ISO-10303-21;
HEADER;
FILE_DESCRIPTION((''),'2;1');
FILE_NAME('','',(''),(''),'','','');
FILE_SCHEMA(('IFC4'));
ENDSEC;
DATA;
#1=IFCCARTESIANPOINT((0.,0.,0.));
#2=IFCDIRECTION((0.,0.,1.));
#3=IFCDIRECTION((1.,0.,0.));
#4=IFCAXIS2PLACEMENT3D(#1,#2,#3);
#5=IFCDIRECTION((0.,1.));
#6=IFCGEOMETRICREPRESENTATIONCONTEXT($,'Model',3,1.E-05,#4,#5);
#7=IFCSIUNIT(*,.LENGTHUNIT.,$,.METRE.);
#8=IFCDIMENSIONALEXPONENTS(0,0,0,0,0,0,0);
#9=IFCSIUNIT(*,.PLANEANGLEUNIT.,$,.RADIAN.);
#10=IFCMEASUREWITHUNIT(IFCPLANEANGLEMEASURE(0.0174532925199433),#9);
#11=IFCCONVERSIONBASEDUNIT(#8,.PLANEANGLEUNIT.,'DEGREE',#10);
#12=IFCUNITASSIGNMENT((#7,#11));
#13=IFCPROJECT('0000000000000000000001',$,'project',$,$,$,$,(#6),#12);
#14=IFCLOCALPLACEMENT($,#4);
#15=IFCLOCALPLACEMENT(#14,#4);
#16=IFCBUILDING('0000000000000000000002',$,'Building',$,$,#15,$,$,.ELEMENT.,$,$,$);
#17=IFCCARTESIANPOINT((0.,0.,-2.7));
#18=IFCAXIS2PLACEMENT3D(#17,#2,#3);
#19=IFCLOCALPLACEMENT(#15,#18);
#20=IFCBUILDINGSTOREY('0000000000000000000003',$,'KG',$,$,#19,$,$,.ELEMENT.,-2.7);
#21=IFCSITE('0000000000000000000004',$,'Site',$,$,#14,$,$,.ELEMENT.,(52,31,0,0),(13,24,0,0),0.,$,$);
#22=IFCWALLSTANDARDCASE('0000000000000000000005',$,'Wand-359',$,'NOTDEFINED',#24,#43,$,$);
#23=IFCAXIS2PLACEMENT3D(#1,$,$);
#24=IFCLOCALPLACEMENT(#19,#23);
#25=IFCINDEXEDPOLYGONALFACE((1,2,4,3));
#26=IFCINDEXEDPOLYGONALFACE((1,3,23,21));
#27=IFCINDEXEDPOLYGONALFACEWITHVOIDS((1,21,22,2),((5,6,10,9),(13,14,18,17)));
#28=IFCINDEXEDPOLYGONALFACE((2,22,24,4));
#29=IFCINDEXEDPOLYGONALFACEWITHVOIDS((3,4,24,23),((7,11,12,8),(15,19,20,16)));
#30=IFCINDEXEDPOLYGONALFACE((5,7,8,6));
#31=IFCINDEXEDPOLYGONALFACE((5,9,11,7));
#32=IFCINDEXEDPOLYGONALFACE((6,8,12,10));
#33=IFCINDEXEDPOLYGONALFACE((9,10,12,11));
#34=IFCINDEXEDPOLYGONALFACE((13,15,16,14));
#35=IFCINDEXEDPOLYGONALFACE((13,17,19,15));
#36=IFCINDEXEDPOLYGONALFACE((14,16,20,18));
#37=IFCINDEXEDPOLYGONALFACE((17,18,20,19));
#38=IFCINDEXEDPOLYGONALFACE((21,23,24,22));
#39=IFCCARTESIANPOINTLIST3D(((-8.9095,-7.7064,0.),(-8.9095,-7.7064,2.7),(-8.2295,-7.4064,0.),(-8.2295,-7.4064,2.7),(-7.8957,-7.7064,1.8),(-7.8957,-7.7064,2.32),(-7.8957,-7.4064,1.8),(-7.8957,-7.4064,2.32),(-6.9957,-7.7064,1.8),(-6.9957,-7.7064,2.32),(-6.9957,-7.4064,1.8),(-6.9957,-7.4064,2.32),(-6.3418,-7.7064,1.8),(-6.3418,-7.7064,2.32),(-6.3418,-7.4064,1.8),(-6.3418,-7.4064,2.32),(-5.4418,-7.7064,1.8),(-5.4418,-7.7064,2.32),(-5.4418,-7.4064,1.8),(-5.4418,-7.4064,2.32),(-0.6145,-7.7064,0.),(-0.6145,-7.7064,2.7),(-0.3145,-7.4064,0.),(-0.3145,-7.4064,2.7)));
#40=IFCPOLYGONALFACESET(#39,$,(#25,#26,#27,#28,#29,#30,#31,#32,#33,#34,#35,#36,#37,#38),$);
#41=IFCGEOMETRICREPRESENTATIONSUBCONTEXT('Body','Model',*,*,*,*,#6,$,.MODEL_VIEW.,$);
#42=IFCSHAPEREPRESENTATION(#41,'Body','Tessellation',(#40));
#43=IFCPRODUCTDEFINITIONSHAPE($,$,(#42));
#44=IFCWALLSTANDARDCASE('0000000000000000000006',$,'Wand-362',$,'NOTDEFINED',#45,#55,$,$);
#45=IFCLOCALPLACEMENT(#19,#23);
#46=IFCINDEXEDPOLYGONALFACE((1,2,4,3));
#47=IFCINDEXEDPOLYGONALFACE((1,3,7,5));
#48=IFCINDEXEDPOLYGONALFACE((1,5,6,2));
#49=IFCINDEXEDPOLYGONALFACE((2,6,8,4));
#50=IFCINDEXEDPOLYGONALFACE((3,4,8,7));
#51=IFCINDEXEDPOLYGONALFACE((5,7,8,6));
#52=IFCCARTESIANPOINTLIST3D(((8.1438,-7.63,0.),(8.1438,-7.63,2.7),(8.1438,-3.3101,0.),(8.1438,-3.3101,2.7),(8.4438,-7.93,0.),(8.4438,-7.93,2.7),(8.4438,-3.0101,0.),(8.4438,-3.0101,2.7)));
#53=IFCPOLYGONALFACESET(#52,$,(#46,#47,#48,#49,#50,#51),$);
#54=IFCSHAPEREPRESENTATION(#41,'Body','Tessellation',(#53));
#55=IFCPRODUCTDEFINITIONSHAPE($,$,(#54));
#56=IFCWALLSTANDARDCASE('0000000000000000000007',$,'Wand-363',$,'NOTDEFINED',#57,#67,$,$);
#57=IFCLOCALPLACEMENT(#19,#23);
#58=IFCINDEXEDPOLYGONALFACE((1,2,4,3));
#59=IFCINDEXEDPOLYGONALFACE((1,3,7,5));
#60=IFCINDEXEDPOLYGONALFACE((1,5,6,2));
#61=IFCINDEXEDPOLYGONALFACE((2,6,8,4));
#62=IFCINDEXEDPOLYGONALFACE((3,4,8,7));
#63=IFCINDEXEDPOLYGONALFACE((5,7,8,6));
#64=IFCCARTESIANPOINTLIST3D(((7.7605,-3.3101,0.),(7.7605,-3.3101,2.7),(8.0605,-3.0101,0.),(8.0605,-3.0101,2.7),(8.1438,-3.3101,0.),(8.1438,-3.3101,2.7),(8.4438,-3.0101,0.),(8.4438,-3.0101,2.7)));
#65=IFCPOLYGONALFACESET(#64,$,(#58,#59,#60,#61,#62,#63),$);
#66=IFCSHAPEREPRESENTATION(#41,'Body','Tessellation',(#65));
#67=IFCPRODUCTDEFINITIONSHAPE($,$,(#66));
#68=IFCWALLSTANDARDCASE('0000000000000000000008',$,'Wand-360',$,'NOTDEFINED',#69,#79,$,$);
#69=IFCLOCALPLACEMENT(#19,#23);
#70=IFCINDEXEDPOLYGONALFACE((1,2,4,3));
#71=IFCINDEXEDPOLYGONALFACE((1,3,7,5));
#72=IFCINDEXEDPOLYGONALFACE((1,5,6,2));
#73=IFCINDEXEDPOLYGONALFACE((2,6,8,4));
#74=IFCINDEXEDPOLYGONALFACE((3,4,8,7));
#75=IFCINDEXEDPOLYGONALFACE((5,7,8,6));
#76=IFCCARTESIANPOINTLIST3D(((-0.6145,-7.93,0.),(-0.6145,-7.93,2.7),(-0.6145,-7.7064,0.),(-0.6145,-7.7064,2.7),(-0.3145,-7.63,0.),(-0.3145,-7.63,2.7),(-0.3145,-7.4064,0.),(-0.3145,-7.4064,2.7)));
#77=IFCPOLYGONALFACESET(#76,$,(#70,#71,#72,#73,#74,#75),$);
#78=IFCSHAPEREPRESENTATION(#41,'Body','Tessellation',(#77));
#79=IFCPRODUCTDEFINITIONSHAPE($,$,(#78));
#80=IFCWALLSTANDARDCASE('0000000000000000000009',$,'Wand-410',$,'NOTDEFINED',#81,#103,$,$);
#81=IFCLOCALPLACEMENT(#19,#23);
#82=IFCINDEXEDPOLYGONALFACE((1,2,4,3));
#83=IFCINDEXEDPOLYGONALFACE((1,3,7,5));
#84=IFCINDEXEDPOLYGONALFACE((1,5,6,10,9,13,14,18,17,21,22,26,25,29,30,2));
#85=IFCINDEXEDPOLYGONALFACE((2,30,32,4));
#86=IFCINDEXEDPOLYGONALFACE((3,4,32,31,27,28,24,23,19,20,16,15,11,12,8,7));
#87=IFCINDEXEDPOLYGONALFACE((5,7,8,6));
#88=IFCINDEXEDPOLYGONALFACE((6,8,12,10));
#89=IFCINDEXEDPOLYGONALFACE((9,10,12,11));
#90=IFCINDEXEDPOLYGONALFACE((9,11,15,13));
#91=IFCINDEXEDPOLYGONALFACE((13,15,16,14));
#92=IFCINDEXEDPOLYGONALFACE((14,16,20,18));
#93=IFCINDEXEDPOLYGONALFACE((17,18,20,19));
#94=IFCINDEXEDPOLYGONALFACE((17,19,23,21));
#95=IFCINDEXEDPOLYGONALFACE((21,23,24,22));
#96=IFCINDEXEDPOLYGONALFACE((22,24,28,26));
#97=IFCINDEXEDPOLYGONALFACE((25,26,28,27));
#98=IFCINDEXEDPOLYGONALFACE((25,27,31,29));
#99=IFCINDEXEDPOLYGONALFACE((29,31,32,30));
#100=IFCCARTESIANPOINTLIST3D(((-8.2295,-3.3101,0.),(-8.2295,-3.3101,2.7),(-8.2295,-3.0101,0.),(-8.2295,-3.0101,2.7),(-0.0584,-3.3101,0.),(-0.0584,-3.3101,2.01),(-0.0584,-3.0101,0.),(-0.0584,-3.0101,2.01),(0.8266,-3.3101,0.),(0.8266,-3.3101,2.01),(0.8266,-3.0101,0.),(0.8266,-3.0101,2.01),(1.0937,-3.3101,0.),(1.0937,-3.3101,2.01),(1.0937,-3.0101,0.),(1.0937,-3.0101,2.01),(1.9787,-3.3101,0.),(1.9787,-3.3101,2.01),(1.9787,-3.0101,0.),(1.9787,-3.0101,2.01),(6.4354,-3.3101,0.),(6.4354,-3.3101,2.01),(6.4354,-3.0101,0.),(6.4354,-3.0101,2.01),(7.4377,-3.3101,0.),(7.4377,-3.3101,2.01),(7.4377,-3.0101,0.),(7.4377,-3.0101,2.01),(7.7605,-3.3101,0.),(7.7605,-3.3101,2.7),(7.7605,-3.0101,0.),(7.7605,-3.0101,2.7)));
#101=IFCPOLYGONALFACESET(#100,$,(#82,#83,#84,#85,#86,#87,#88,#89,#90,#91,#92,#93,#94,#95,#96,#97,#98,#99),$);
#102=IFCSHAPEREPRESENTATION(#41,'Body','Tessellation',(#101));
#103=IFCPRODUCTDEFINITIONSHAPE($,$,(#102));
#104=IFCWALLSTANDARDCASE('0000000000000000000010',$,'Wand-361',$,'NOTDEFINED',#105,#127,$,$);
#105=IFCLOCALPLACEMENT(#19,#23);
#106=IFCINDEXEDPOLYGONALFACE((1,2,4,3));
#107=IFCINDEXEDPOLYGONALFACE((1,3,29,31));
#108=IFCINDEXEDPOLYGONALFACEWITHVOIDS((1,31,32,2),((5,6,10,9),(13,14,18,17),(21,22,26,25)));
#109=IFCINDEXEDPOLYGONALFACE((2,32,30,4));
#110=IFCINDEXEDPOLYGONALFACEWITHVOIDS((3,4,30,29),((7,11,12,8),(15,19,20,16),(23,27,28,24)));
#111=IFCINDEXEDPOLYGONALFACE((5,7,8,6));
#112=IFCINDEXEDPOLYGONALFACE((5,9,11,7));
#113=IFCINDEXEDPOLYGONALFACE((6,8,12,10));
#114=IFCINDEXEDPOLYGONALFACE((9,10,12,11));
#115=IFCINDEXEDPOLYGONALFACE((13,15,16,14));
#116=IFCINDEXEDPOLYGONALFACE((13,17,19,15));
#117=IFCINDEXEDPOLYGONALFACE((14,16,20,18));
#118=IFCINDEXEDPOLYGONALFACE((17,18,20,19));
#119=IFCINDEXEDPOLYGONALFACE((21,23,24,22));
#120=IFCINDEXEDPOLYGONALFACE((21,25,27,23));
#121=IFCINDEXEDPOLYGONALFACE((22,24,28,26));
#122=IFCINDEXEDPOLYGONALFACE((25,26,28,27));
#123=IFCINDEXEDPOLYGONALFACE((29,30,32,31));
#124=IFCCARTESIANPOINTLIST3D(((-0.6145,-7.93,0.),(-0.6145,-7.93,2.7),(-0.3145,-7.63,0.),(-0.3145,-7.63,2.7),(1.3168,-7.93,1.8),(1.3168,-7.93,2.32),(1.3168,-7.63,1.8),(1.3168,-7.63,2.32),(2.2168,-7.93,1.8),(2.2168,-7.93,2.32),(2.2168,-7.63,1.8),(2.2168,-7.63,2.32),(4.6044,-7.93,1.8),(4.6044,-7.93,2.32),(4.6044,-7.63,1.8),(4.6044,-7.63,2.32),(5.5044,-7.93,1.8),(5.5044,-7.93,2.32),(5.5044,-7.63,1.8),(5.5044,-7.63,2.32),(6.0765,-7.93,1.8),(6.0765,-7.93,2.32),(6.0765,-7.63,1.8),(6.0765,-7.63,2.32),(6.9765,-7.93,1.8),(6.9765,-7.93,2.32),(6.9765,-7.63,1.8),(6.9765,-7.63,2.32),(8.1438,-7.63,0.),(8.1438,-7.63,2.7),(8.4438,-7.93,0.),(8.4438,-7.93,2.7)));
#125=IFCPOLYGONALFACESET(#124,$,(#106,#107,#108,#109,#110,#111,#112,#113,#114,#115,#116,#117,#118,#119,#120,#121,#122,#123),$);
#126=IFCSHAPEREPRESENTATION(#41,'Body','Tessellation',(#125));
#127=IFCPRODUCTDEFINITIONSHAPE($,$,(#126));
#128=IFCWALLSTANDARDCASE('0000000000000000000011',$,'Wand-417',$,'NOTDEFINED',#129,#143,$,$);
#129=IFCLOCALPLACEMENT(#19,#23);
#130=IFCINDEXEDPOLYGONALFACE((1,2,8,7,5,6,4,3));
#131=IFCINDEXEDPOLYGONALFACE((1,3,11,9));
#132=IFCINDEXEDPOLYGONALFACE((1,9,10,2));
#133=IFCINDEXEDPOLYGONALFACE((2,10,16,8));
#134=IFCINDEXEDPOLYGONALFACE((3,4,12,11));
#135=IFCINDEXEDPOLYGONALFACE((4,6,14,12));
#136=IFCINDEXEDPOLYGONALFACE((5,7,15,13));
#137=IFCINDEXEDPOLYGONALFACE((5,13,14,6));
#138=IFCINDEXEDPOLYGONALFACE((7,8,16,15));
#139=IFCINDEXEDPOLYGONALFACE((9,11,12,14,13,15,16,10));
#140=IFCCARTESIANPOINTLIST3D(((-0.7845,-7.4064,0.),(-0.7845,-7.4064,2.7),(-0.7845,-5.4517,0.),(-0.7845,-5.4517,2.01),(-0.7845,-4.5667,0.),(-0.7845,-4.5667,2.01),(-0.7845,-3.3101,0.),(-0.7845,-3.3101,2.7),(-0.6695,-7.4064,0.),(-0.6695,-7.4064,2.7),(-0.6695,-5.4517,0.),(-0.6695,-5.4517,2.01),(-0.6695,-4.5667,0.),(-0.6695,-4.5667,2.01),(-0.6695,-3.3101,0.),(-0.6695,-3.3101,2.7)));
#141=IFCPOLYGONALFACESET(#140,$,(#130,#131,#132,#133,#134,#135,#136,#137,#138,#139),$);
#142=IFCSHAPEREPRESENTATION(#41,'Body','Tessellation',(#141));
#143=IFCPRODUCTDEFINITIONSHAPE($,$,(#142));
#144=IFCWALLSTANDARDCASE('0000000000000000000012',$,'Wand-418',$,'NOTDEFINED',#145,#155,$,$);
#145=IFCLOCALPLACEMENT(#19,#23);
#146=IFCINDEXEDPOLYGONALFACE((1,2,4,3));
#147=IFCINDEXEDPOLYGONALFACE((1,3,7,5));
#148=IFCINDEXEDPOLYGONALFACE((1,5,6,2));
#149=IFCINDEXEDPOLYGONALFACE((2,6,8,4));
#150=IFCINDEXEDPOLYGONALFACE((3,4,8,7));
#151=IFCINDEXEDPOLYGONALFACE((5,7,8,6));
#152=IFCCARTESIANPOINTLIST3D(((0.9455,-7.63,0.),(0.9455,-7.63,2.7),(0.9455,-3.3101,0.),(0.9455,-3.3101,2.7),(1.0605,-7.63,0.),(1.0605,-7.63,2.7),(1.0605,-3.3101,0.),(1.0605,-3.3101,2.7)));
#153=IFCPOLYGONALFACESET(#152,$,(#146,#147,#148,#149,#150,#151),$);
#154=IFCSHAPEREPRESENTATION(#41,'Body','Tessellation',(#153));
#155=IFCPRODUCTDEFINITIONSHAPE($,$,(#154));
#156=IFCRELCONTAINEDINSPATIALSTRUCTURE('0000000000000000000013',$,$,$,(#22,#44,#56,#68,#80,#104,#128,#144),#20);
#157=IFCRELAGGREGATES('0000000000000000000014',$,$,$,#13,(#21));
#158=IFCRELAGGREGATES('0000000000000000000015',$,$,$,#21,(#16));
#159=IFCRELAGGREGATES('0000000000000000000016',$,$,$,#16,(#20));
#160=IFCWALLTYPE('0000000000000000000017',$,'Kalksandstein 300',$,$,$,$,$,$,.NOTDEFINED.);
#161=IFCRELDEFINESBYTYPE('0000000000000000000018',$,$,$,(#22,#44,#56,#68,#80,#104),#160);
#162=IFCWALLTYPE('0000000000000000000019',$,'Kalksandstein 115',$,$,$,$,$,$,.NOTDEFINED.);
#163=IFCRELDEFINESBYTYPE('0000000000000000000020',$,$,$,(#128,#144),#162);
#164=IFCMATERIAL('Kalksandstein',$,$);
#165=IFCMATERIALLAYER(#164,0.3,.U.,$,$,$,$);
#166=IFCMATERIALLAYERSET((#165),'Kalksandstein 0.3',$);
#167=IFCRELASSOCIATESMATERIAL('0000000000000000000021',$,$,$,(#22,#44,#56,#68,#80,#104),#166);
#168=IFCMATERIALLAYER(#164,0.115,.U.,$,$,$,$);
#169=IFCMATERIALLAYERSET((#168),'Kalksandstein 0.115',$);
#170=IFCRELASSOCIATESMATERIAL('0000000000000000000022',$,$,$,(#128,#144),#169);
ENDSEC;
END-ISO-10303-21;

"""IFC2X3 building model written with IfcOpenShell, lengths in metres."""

from ifc_helpers import new_model, entity, si_unit, converted_unit, direction, frame, origin_with_axes, origin_2d_with_axis, place, context, subcontext, project, spatial, polyline, rectangle, outline, extrude, material, layer, layer_set, layer_usage, type_object, element, save


model = new_model("IFC2X3")

# Units and contexts
model_context = context("Model", 3, precision=1e-05, world=origin_with_axes(), true_north=direction((0.0, 1.0)))
body_context = subcontext(model_context, "Body", "Model", "MODEL_VIEW")
ifc_project = project(units=[si_unit("LENGTHUNIT", "METRE"), converted_unit("PLANEANGLEUNIT", "DEGREE", entity("IfcPlaneAngleMeasure", 0.0174532925199433), si_unit("PLANEANGLEUNIT", "RADIAN"), dimensions=[0, 0, 0, 0, 0, 0, 0])], contexts=[model_context])

# Site, building, storey
site_placement = place(None, origin_with_axes())
site = spatial("IfcSite", under=ifc_project, at=site_placement, Name="Site", CompositionType="ELEMENT", RefLatitude=(52, 31, 0, 0), RefLongitude=(13, 24, 0, 0), RefElevation=0.0)
building_placement = place(site_placement, origin_with_axes())
building = spatial("IfcBuilding", under=site, at=building_placement, Name="Building", CompositionType="ELEMENT")
storey_placement = place(building_placement, frame((0.0, 0.0, -2.7), z_axis=(0.0, 0.0, 1.0), x_axis=(1.0, 0.0, 0.0)))
storey = spatial("IfcBuildingStorey", under=building, at=storey_placement, Name="KG", CompositionType="ELEMENT", Elevation=-2.7)

# Wall, openings
ifc_material = material(Name="Kalksandstein")
ifc_layer_1 = layer(ifc_material, 0.3, ventilated="UNKNOWN")
ifc_layer_set_1 = layer_set([ifc_layer_1], Name="Kalksandstein 0.3")
ifc_layer_usage_1 = layer_usage(ifc_layer_set_1, "AXIS2", "POSITIVE", 0.0)
wall_type_1 = type_object("IfcWallType", Name="Kalksandstein 300", PredefinedType="NOTDEFINED")
wall_1_placement = place(storey_placement, frame((-8.9095, -7.7064, 0.0), z_axis=(0.0, 0.0, 1.0), x_axis=(1.0, 0.0, 0.0)))
wall_1 = element("IfcWallStandardCase", 1, at=wall_1_placement, inside=storey, type_object=wall_type_1, material=ifc_layer_usage_1, Name="Wand-359", ObjectType="NOTDEFINED", context=body_context, shape_type="SweptSolid", body=[
    extrude(outline(polyline([(0.0, 0.0), (8.295, 0.0), (8.595, 0.3), (0.68, 0.3), (0.0, 0.0)])), origin_with_axes(), (0.0, 0.0, 1.0), 2.7),
])
opening_1_placement = place(wall_1_placement, frame((3.0176, 0.0, 1.8), z_axis=(0.0, 0.0, 1.0), x_axis=(1.0, 0.0, 0.0)))
element("IfcOpeningElement", 2, at=opening_1_placement, cuts=wall_1, context=body_context, shape_type="SweptSolid", body=[
    extrude(rectangle(XDim=0.9, YDim=0.52, at=origin_2d_with_axis()), frame((0.0, 0.3, 0.26), z_axis=(0.0, -1.0, 0.0), x_axis=(-1.0, 0.0, 0.0)), (0.0, 0.0, 1.0), 0.9),
])
opening_2_placement = place(wall_1_placement, frame((1.4637, 0.0, 1.8), z_axis=(0.0, 0.0, 1.0), x_axis=(1.0, 0.0, 0.0)))
element("IfcOpeningElement", 3, at=opening_2_placement, cuts=wall_1, context=body_context, shape_type="SweptSolid", body=[
    extrude(rectangle(XDim=0.9, YDim=0.52, at=origin_2d_with_axis()), frame((0.0, 0.3, 0.26), z_axis=(0.0, -1.0, 0.0), x_axis=(-1.0, 0.0, 0.0)), (0.0, 0.0, 1.0), 0.9),
])

# Walls
ifc_layer_usage_2 = layer_usage(ifc_layer_set_1, "AXIS2", "POSITIVE", 0.0)
wall_2_placement = place(storey_placement, frame((8.4438, -7.93, 0.0), z_axis=(0.0, 0.0, 1.0), x_axis=(0.0, 1.0, 0.0)))
element("IfcWallStandardCase", 4, at=wall_2_placement, inside=storey, type_object=wall_type_1, material=ifc_layer_usage_2, Name="Wand-362", ObjectType="NOTDEFINED", context=body_context, shape_type="SweptSolid", body=[
    extrude(outline(polyline([(0.0, 0.0), (4.9199, 0.0), (4.6199, 0.3), (0.3, 0.3), (0.0, 0.0)])), origin_with_axes(), (0.0, 0.0, 1.0), 2.7),
])
ifc_layer_usage_3 = layer_usage(ifc_layer_set_1, "AXIS2", "POSITIVE", 0.0)
wall_3_placement = place(storey_placement, frame((8.4438, -3.0101, 0.0), z_axis=(0.0, 0.0, 1.0), x_axis=(-1.0, 0.0, 0.0)))
element("IfcWallStandardCase", 5, at=wall_3_placement, inside=storey, type_object=wall_type_1, material=ifc_layer_usage_3, Name="Wand-363", ObjectType="NOTDEFINED", context=body_context, shape_type="SweptSolid", body=[
    extrude(outline(polyline([(0.0, 0.0), (0.3833, 0.0), (0.6833, 0.3), (0.3, 0.3), (0.0, 0.0)])), origin_with_axes(), (0.0, 0.0, 1.0), 2.7),
])
ifc_layer_usage_4 = layer_usage(ifc_layer_set_1, "AXIS2", "POSITIVE", 0.0)
wall_4_placement = place(storey_placement, frame((-0.6145, -7.7064, 0.0), z_axis=(0.0, 0.0, 1.0), x_axis=(0.0, -1.0, 0.0)))
element("IfcWallStandardCase", 6, at=wall_4_placement, inside=storey, type_object=wall_type_1, material=ifc_layer_usage_4, Name="Wand-360", ObjectType="NOTDEFINED", context=body_context, shape_type="SweptSolid", body=[
    extrude(outline(polyline([(0.0, 0.0), (0.2237, 0.0), (-0.0763, 0.3), (-0.3, 0.3), (0.0, 0.0)])), origin_with_axes(), (0.0, 0.0, 1.0), 2.7),
])

# Walls, openings
ifc_layer_usage_5 = layer_usage(ifc_layer_set_1, "AXIS2", "NEGATIVE", 0.0)
wall_5_placement = place(storey_placement, frame((7.7605, -3.3101, 0.0), z_axis=(0.0, 0.0, 1.0), x_axis=(-1.0, 0.0, 0.0)))
wall_5 = element("IfcWallStandardCase", 7, at=wall_5_placement, inside=storey, type_object=wall_type_1, material=ifc_layer_usage_5, Name="Wand-410", ObjectType="NOTDEFINED", context=body_context, shape_type="SweptSolid", body=[
    extrude(outline(polyline([(0.0, -0.3), (15.99, -0.3), (15.99, 0.0), (0.0, 0.0), (0.0, -0.3)])), origin_with_axes(), (0.0, 0.0, 1.0), 2.7),
])
opening_3_placement = place(wall_5_placement, frame((0.824, 0.0, 0.0), z_axis=(0.0, 0.0, 1.0), x_axis=(1.0, 0.0, 0.0)))
element("IfcOpeningElement", 8, at=opening_3_placement, cuts=wall_5, context=body_context, shape_type="SweptSolid", body=[
    extrude(rectangle(XDim=1.0023, YDim=2.01, at=origin_2d_with_axis()), frame((0.0, -0.3, 1.005), z_axis=(0.0, -1.0, 0.0), x_axis=(-1.0, 0.0, 0.0)), (0.0, 0.0, -1.0), 0.9),
])
opening_4_placement = place(wall_5_placement, frame((7.3765, 0.0, 0.0), z_axis=(0.0, 0.0, 1.0), x_axis=(1.0, 0.0, 0.0)))
element("IfcOpeningElement", 9, at=opening_4_placement, cuts=wall_5, context=body_context, shape_type="SweptSolid", body=[
    extrude(rectangle(XDim=0.885, YDim=2.01, at=origin_2d_with_axis()), frame((0.0, -0.3, 1.005), z_axis=(0.0, -1.0, 0.0), x_axis=(-1.0, 0.0, 0.0)), (0.0, 0.0, -1.0), 0.9),
])
opening_5_placement = place(wall_5_placement, frame((6.2243, 0.0, 0.0), z_axis=(0.0, 0.0, 1.0), x_axis=(1.0, 0.0, 0.0)))
element("IfcOpeningElement", 10, at=opening_5_placement, cuts=wall_5, context=body_context, shape_type="SweptSolid", body=[
    extrude(rectangle(XDim=0.885, YDim=2.01, at=origin_2d_with_axis()), frame((0.0, -0.3, 1.005), z_axis=(0.0, 1.0, 0.0), x_axis=(1.0, 0.0, 0.0)), (0.0, 0.0, 1.0), 0.9),
])
ifc_layer_usage_6 = layer_usage(ifc_layer_set_1, "AXIS2", "POSITIVE", 0.0)
wall_6_placement = place(storey_placement, frame((-0.6145, -7.93, 0.0), z_axis=(0.0, 0.0, 1.0), x_axis=(1.0, 0.0, 0.0)))
wall_6 = element("IfcWallStandardCase", 11, at=wall_6_placement, inside=storey, type_object=wall_type_1, material=ifc_layer_usage_6, Name="Wand-361", ObjectType="NOTDEFINED", context=body_context, shape_type="SweptSolid", body=[
    extrude(outline(polyline([(0.0, 0.0), (9.0583, 0.0), (8.7583, 0.3), (0.3, 0.3), (0.0, 0.0)])), origin_with_axes(), (0.0, 0.0, 1.0), 2.7),
])
opening_6_placement = place(wall_6_placement, frame((2.3812, 0.0, 1.8), z_axis=(0.0, 0.0, 1.0), x_axis=(1.0, 0.0, 0.0)))
element("IfcOpeningElement", 12, at=opening_6_placement, cuts=wall_6, context=body_context, shape_type="SweptSolid", body=[
    extrude(rectangle(XDim=0.9, YDim=0.52, at=origin_2d_with_axis()), frame((0.0, 0.3, 0.26), z_axis=(0.0, -1.0, 0.0), x_axis=(-1.0, 0.0, 0.0)), (0.0, 0.0, 1.0), 0.9),
])
opening_7_placement = place(wall_6_placement, frame((5.6689, 0.0, 1.8), z_axis=(0.0, 0.0, 1.0), x_axis=(1.0, 0.0, 0.0)))
element("IfcOpeningElement", 13, at=opening_7_placement, cuts=wall_6, context=body_context, shape_type="SweptSolid", body=[
    extrude(rectangle(XDim=0.9, YDim=0.52, at=origin_2d_with_axis()), frame((0.0, 0.3, 0.26), z_axis=(0.0, -1.0, 0.0), x_axis=(-1.0, 0.0, 0.0)), (0.0, 0.0, 1.0), 0.9),
])
opening_8_placement = place(wall_6_placement, frame((7.141, 0.0, 1.8), z_axis=(0.0, 0.0, 1.0), x_axis=(1.0, 0.0, 0.0)))
element("IfcOpeningElement", 14, at=opening_8_placement, cuts=wall_6, context=body_context, shape_type="SweptSolid", body=[
    extrude(rectangle(XDim=0.9, YDim=0.52, at=origin_2d_with_axis()), frame((0.0, 0.3, 0.26), z_axis=(0.0, -1.0, 0.0), x_axis=(-1.0, 0.0, 0.0)), (0.0, 0.0, 1.0), 0.9),
])

# Shared definitions
ifc_layer_2 = layer(ifc_material, 0.115, ventilated="UNKNOWN")
ifc_layer_set_2 = layer_set([ifc_layer_2], Name="Kalksandstein 0.115")
wall_type_2 = type_object("IfcWallType", Name="Kalksandstein 115", PredefinedType="NOTDEFINED")

# Wall, opening
ifc_layer_usage_7 = layer_usage(ifc_layer_set_2, "AXIS2", "POSITIVE", 0.0)
wall_7_placement = place(storey_placement, frame((-0.7845, -3.3101, 0.0), z_axis=(0.0, 0.0, 1.0), x_axis=(0.0, -1.0, 0.0)))
wall_7 = element("IfcWallStandardCase", 15, at=wall_7_placement, inside=storey, type_object=wall_type_2, material=ifc_layer_usage_7, Name="Wand-417", ObjectType="NOTDEFINED", context=body_context, shape_type="SweptSolid", body=[
    extrude(outline(polyline([(0.0, 0.0), (4.0962, 0.0), (4.0962, 0.115), (0.0, 0.115), (0.0, 0.0)])), origin_with_axes(), (0.0, 0.0, 1.0), 2.7),
])
opening_9_placement = place(wall_7_placement, frame((1.6991, 0.0, 0.0), z_axis=(0.0, 0.0, 1.0), x_axis=(1.0, 0.0, 0.0)))
element("IfcOpeningElement", 16, at=opening_9_placement, cuts=wall_7, context=body_context, shape_type="SweptSolid", body=[
    extrude(rectangle(XDim=0.885, YDim=2.01, at=origin_2d_with_axis()), frame((0.0, 0.115, 1.005), z_axis=(0.0, -1.0, 0.0), x_axis=(-1.0, 0.0, 0.0)), (0.0, 0.0, 1.0), 0.345),
])

# Wall
ifc_layer_usage_8 = layer_usage(ifc_layer_set_2, "AXIS2", "POSITIVE", 0.0)
wall_8_placement = place(storey_placement, frame((0.9455, -3.3101, 0.0), z_axis=(0.0, 0.0, 1.0), x_axis=(0.0, -1.0, 0.0)))
element("IfcWallStandardCase", 17, at=wall_8_placement, inside=storey, type_object=wall_type_2, material=ifc_layer_usage_8, Name="Wand-418", ObjectType="NOTDEFINED", context=body_context, shape_type="SweptSolid", body=[
    extrude(outline(polyline([(0.0, 0.0), (4.3199, 0.0), (4.3199, 0.115), (0.0, 0.115), (0.0, 0.0)])), origin_with_axes(), (0.0, 0.0, 1.0), 2.7),
])

save(model, "model.ifc")
